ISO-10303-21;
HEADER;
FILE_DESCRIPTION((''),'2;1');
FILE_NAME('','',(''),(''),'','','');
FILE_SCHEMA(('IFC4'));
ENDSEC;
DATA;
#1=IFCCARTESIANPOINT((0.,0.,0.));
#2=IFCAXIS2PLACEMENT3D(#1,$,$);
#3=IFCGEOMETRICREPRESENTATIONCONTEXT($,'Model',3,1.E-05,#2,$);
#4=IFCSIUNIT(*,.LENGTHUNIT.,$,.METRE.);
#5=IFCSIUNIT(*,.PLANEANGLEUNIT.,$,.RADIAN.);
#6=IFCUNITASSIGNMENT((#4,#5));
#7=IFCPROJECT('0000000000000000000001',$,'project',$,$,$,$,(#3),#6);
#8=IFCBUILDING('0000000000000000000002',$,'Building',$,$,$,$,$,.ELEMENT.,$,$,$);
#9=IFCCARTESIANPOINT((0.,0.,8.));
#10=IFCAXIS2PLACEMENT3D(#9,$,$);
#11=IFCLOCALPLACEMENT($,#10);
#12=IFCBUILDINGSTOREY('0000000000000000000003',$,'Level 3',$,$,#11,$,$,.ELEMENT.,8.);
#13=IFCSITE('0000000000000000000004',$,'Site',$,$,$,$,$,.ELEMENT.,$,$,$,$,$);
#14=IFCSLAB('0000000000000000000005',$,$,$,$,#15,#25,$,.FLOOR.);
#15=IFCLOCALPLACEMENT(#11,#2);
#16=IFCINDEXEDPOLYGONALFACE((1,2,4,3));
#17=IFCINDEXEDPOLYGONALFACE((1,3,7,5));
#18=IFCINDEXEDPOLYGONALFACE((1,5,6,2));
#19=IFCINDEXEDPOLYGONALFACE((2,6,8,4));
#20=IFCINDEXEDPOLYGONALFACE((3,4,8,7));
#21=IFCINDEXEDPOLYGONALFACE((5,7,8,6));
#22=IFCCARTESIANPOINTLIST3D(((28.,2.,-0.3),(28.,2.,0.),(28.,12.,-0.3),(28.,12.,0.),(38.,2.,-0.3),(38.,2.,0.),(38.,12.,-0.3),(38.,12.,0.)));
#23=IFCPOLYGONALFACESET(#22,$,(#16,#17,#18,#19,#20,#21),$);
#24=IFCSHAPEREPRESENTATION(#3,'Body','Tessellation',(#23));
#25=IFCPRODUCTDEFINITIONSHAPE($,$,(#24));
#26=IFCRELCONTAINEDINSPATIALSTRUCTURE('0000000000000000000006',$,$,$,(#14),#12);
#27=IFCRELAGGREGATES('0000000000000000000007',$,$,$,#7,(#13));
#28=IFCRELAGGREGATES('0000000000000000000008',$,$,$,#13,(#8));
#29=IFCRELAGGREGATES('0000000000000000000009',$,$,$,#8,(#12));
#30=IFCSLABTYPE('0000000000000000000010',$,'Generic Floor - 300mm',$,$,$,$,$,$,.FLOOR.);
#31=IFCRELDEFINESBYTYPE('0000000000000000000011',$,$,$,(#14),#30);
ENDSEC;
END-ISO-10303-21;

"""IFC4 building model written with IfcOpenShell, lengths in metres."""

from ifc_helpers import new_model, si_unit, frame, origin, place, context, project, spatial, polyline, outline, extrude, type_object, element, save


model = new_model("IFC4")

# Units and contexts
model_context = context("Model", 3, precision=1e-05, world=origin())
ifc_project = project(units=[si_unit("LENGTHUNIT", "METRE"), si_unit("PLANEANGLEUNIT", "RADIAN")], contexts=[model_context])

# Site, building, storey
site = spatial("IfcSite", under=ifc_project, Name="Site", CompositionType="ELEMENT")
building = spatial("IfcBuilding", under=site, Name="Building", CompositionType="ELEMENT")
storey_placement = place(None, frame((0.0, 0.0, 8.0)))
storey = spatial("IfcBuildingStorey", under=building, at=storey_placement, Name="Level 3", CompositionType="ELEMENT", Elevation=8.0)

# Slab
slab_type = type_object("IfcSlabType", Name="Generic Floor - 300mm", PredefinedType="FLOOR")
slab_placement = place(None, frame((0.0, 0.0, 8.0)))
element("IfcSlab", 1, at=slab_placement, inside=storey, type_object=slab_type, PredefinedType="FLOOR", context=model_context, shape_type="SweptSolid", body=[
    extrude(outline(polyline([(28.0, 12.0), (28.0, 2.0), (38.0, 2.0), (38.0, 12.0), (28.0, 12.0)])), origin(), (0.0, 0.0, -1.0), 0.3),
])

save(model, "model.ifc")
